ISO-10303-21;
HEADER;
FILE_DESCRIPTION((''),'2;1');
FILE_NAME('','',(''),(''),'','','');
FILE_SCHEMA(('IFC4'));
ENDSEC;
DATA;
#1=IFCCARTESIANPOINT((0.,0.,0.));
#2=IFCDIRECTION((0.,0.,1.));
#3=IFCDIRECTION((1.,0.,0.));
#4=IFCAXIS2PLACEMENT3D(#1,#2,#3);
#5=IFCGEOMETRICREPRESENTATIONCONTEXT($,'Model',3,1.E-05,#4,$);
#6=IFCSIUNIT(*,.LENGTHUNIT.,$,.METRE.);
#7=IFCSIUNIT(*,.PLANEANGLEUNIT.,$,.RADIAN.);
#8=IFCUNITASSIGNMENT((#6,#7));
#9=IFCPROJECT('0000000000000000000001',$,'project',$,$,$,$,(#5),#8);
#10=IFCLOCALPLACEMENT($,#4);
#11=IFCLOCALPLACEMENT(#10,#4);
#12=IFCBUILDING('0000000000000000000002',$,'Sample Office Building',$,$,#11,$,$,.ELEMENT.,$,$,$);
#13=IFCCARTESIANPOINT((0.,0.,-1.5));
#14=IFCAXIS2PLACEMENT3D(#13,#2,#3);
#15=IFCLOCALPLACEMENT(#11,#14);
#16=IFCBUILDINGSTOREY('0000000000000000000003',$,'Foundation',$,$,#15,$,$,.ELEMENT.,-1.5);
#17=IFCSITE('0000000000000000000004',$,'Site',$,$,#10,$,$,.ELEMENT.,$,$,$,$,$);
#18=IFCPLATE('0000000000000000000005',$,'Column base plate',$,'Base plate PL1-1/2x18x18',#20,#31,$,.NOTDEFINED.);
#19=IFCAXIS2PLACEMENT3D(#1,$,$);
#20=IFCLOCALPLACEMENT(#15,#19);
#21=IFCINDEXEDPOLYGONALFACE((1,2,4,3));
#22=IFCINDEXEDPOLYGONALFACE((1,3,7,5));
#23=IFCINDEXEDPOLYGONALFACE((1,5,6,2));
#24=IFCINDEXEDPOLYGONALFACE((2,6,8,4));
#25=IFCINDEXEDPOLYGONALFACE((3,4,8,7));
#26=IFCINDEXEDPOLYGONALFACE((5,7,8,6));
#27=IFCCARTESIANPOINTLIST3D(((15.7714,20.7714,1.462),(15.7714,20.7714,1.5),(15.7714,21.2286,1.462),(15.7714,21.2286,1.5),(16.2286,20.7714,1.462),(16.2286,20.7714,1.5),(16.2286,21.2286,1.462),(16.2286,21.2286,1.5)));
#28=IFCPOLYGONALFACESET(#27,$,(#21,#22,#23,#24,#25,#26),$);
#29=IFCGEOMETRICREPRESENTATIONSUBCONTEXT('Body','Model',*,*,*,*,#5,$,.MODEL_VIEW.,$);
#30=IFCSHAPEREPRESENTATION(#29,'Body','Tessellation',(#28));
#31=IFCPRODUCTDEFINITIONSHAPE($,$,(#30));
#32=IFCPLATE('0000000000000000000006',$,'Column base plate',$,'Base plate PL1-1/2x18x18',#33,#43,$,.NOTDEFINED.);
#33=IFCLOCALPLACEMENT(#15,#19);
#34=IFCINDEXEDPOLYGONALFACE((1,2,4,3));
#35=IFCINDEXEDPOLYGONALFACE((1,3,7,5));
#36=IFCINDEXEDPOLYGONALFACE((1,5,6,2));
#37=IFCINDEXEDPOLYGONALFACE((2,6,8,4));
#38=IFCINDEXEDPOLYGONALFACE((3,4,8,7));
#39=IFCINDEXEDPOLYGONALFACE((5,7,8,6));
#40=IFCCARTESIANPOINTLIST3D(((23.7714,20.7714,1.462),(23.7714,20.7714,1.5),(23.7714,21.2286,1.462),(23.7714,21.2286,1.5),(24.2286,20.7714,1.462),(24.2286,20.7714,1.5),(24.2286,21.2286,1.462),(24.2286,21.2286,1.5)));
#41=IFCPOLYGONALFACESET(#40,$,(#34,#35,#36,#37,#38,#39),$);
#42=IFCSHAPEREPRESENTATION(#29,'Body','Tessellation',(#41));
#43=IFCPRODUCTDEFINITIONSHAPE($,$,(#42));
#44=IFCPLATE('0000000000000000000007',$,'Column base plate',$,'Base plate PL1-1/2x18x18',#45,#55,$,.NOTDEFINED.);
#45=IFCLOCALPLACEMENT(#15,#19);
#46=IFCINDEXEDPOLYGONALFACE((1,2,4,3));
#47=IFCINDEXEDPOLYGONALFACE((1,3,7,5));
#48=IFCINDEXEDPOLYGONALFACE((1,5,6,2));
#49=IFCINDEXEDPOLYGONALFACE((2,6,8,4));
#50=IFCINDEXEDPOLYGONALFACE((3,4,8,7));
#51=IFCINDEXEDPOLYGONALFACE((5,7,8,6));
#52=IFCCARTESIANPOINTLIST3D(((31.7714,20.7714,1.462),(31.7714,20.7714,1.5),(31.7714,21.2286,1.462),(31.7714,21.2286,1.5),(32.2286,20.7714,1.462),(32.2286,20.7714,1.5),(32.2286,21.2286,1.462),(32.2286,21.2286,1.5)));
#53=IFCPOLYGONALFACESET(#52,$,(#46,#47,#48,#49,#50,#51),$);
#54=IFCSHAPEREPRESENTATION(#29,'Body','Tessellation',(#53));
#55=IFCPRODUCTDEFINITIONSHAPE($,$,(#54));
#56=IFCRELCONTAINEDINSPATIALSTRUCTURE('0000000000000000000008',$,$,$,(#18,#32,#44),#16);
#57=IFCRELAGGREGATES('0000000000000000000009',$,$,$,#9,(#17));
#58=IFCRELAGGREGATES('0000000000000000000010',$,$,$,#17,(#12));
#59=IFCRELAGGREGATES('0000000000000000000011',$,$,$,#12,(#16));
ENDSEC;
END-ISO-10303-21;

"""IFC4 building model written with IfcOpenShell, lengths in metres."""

from ifc_helpers import new_model, si_unit, frame, origin_with_axes, place, context, subcontext, project, spatial, rectangle, extrude, element, save


model = new_model("IFC4")

# Units and contexts
model_context = context("Model", 3, precision=1e-05, world=origin_with_axes())
body_context = subcontext(model_context, "Body", "Model", "MODEL_VIEW")
ifc_project = project(units=[si_unit("LENGTHUNIT", "METRE"), si_unit("PLANEANGLEUNIT", "RADIAN")], contexts=[model_context])

# Site, building, storey
site_placement = place(None, origin_with_axes())
site = spatial("IfcSite", under=ifc_project, at=site_placement, Name="Site", CompositionType="ELEMENT")
building_placement = place(site_placement, origin_with_axes())
building = spatial("IfcBuilding", under=site, at=building_placement, Name="Sample Office Building", CompositionType="ELEMENT")
storey_placement = place(building_placement, frame((0.0, 0.0, -1.5), z_axis=(0.0, 0.0, 1.0), x_axis=(1.0, 0.0, 0.0)))
storey = spatial("IfcBuildingStorey", under=building, at=storey_placement, Name="Foundation", CompositionType="ELEMENT", Elevation=-1.5)

# Plates
for number, where, z_axis, x_axis, name in (
    (1, (16.0, 21.0, -0.038), (0.0, 0.0, 1.0), (1.0, 0.0, 0.0), "Column base plate"),
    (2, (24.0, 21.0, -0.038), (0.0, 0.0, 1.0), (1.0, 0.0, 0.0), "Column base plate"),
    (3, (32.0, 21.0, -0.038), (0.0, 0.0, 1.0), (1.0, 0.0, 0.0), "Column base plate"),
):
    element("IfcPlate", number, at=place(None, frame(where, z_axis=z_axis, x_axis=x_axis)), inside=storey, Name=name, ObjectType="Base plate PL1-1/2x18x18", PredefinedType="NOTDEFINED", context=body_context, shape_type="SweptSolid", body=[
        extrude(rectangle(XDim=0.4572, YDim=0.4572), None, (0.0, 0.0, 1.0), 0.038),
    ])

save(model, "model.ifc")
